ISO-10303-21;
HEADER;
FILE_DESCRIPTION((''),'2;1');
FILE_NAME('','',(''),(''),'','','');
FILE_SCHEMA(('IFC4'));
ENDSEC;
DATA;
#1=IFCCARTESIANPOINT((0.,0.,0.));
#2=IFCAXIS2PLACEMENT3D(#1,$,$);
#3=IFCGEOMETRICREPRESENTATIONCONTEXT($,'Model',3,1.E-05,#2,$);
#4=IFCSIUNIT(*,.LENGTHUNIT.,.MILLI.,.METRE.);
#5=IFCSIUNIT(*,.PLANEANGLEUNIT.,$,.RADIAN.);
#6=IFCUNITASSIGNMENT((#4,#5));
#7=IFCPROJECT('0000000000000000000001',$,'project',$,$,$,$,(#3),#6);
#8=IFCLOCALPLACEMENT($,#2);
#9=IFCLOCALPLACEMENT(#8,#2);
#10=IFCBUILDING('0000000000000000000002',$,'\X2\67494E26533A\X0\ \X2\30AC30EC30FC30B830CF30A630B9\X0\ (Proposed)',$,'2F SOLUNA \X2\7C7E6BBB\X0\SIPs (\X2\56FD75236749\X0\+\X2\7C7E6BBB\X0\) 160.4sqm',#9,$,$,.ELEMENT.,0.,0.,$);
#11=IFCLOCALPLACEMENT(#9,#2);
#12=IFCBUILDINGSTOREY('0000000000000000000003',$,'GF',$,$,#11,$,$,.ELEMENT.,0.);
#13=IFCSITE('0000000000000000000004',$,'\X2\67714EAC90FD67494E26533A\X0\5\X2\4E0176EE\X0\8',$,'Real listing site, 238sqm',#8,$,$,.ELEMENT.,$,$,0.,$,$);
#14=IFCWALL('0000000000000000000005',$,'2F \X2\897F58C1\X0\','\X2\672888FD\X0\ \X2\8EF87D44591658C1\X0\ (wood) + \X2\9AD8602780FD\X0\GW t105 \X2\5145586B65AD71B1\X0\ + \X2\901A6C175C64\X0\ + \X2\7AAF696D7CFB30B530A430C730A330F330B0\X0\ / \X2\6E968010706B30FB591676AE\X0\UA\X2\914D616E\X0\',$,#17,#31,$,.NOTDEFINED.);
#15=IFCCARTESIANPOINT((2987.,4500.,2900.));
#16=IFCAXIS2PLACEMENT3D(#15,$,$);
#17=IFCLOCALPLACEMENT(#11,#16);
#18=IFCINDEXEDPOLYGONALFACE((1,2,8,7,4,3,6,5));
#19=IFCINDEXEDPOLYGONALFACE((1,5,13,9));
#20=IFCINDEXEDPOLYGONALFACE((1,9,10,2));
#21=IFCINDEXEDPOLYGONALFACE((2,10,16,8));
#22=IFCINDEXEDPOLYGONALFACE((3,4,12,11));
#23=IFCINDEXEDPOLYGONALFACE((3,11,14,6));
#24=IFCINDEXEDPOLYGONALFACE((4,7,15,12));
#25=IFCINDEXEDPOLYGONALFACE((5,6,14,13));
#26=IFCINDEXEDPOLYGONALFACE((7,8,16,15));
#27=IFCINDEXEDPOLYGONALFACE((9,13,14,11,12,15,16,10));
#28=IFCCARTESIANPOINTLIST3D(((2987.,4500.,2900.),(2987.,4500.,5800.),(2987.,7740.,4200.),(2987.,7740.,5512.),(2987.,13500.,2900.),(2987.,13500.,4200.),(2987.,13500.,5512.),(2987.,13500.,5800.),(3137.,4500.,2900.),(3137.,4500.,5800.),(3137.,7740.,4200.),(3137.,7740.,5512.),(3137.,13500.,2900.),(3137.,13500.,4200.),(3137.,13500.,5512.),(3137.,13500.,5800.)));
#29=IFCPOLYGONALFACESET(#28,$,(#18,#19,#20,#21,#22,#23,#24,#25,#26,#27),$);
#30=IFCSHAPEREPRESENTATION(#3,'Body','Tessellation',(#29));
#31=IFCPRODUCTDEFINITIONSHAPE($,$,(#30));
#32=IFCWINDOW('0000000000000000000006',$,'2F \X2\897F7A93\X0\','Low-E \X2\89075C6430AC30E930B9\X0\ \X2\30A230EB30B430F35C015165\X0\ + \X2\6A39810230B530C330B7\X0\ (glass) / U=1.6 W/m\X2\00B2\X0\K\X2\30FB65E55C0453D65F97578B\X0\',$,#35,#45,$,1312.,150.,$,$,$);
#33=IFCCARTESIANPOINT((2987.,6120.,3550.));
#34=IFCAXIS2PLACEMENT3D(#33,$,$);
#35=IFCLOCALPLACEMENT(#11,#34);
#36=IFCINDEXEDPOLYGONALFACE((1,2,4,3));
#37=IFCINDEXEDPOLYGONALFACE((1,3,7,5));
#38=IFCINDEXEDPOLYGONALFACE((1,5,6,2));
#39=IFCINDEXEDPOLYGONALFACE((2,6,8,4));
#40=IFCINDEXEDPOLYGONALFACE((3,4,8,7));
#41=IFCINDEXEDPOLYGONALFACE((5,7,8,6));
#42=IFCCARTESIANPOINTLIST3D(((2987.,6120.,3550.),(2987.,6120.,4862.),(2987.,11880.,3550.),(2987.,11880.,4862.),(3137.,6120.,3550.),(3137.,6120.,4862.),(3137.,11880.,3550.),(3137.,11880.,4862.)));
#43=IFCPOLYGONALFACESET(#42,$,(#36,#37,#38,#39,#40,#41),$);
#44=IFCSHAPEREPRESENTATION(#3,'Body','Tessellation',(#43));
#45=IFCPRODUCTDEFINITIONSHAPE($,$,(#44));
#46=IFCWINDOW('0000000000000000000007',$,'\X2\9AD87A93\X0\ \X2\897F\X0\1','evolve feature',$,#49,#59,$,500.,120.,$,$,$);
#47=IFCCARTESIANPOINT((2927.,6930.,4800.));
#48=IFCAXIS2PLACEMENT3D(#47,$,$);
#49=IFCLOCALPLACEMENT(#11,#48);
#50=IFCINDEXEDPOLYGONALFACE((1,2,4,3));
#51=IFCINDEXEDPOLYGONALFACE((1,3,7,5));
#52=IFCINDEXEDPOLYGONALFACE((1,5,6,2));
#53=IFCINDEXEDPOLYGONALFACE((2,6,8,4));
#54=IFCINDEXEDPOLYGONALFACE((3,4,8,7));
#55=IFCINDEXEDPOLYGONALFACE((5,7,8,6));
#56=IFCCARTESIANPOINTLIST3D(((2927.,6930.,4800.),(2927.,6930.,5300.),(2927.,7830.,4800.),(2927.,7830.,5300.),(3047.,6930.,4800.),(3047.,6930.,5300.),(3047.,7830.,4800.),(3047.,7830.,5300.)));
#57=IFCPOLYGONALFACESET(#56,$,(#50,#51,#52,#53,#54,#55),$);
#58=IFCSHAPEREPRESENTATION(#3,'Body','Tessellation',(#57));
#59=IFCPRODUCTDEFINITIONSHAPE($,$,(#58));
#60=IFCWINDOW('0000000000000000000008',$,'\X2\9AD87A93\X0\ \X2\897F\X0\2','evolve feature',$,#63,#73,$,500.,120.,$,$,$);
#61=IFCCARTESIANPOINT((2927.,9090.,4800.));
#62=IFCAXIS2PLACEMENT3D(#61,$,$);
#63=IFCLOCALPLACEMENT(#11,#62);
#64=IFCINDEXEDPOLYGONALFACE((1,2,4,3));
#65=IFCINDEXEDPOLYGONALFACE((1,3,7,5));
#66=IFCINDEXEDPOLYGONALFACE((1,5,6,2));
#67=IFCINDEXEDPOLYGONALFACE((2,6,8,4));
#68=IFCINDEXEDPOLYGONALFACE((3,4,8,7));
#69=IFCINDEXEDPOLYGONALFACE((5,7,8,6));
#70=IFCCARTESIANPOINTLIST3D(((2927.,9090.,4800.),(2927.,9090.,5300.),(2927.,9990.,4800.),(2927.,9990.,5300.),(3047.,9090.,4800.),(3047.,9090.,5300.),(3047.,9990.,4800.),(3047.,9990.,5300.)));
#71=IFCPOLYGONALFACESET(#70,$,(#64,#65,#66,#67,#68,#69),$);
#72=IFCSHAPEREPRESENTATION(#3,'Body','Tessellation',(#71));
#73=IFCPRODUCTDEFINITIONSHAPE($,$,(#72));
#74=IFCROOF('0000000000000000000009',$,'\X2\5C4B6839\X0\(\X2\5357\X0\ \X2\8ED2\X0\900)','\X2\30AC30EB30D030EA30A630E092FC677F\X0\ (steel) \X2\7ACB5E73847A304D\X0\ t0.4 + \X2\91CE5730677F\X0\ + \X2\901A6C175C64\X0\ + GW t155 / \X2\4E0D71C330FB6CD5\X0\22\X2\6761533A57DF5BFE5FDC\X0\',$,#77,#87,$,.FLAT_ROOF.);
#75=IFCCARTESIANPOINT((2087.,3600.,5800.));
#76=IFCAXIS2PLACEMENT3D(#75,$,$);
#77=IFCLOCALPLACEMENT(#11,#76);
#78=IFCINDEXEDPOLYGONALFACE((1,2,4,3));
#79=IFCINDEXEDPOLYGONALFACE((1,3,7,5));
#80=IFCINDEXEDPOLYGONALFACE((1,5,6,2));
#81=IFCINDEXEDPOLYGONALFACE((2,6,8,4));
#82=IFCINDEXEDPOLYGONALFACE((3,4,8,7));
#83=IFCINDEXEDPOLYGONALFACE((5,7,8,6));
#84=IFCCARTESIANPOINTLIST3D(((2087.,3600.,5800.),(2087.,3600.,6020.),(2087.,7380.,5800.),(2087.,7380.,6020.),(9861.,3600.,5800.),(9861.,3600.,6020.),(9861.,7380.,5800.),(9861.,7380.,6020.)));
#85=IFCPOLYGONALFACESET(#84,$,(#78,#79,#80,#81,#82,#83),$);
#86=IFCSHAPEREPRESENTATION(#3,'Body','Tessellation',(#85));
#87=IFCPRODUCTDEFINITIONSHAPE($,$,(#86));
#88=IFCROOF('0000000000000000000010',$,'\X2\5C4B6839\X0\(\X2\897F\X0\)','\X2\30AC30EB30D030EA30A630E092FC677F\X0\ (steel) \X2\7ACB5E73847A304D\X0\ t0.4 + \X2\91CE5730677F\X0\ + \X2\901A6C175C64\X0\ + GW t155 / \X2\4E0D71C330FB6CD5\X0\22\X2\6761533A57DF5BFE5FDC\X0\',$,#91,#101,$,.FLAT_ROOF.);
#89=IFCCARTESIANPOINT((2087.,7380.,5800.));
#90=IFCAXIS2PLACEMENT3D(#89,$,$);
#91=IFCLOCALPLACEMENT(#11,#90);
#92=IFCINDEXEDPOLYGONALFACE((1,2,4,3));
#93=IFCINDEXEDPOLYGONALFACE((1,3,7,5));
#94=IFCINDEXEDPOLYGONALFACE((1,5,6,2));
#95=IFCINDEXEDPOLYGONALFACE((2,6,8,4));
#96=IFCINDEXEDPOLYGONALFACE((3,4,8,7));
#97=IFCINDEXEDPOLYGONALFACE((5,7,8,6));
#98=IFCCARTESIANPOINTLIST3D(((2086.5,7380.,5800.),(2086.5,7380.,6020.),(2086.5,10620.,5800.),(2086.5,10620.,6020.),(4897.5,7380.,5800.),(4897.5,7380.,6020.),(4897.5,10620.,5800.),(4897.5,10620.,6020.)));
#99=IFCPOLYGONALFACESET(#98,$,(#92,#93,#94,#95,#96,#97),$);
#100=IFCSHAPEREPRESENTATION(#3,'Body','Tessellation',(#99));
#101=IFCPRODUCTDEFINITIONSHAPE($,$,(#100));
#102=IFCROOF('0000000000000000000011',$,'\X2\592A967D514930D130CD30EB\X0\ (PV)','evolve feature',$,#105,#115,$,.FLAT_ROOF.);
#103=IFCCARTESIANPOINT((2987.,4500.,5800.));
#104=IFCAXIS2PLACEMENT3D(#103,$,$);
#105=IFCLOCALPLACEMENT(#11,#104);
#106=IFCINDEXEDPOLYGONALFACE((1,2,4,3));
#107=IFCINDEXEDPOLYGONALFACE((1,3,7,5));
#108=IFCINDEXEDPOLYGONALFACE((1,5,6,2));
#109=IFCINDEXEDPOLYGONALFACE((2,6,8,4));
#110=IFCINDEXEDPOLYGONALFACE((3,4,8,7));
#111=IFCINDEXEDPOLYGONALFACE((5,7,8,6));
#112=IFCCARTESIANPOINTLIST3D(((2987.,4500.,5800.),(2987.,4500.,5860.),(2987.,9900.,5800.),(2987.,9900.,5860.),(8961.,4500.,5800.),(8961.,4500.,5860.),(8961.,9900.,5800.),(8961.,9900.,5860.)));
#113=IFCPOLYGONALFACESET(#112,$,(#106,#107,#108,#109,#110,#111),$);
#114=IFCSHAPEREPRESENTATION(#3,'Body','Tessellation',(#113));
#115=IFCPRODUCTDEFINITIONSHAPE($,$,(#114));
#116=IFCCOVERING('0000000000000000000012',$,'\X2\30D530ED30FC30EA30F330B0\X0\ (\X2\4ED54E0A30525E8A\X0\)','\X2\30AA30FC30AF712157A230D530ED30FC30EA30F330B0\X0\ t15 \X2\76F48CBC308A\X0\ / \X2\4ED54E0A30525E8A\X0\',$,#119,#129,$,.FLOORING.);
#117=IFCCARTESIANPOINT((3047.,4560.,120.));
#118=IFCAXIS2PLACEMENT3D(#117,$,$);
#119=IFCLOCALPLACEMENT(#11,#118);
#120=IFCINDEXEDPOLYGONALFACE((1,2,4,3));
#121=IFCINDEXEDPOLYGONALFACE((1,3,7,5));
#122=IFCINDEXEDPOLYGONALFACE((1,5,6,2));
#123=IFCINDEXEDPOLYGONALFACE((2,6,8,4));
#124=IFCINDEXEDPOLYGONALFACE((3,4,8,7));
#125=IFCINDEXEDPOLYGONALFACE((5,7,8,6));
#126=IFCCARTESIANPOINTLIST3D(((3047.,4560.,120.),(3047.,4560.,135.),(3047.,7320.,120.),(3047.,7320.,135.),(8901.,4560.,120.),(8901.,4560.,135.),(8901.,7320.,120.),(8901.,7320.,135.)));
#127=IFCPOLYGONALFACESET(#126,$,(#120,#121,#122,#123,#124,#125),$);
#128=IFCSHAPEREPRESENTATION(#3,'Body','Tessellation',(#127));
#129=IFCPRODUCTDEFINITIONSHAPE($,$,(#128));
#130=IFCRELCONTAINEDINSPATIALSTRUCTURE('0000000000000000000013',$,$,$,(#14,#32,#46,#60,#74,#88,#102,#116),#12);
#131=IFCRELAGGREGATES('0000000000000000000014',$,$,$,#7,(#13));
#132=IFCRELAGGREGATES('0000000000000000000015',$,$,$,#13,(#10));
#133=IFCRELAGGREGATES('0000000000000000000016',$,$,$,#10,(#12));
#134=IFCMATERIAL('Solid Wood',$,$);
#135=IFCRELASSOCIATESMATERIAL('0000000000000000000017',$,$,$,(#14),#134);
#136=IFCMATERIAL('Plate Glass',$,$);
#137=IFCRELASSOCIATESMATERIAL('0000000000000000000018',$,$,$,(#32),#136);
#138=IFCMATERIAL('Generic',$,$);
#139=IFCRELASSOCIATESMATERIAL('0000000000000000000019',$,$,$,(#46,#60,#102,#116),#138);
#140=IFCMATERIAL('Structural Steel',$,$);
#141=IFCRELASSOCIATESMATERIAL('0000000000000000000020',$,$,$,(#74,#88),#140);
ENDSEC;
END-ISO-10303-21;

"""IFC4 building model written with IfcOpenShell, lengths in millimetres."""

from ifc_helpers import new_model, si_unit, frame, frame_2d, origin, place, context, project, spatial, rectangle, extrude, material, element, fill, save


model = new_model("IFC4")

# Units and contexts
model_context = context("Model", 3, precision=1e-05, world=origin())
ifc_project = project(units=[si_unit("LENGTHUNIT", "METRE", prefix="MILLI"), si_unit("PLANEANGLEUNIT", "RADIAN")], contexts=[model_context])

# Site, building, storey
site_placement = place(None, origin())
site = spatial("IfcSite", under=ifc_project, at=site_placement, Name="東京都杉並区5丁目8", ObjectType="Real listing site, 238sqm", CompositionType="ELEMENT", RefElevation=0.0)
building_placement = place(site_placement, origin())
building = spatial("IfcBuilding", under=site, at=building_placement, Name="杉並区 ガレージハウス (Proposed)", ObjectType="2F SOLUNA 籾殻SIPs (国産杉+籾殻) 160.4sqm", CompositionType="ELEMENT", ElevationOfRefHeight=0.0, ElevationOfTerrain=0.0)
storey_placement = place(building_placement, origin())
storey = spatial("IfcBuildingStorey", under=building, at=storey_placement, Name="GF", CompositionType="ELEMENT", Elevation=0.0)

# Shared definitions
ifc_material_1 = material(Name="Solid Wood")
ifc_material_2 = material(Name="Generic")

# Shared definitions
ifc_material_3 = material(Name="Plate Glass")

# Wall, openings, windows
wall_1_placement = place(storey_placement, frame((2987.0, 4500.0, 2900.0)))
wall_1 = element("IfcWall", 1, at=wall_1_placement, inside=storey, material=ifc_material_1, Name="2F 西壁", Description="木製 軸組外壁 (wood) + 高性能GW t105 充填断熱 + 通気層 + 窯業系サイディング / 準耐火・外皮UA配慮", PredefinedType="NOTDEFINED", context=model_context, shape_type="SweptSolid", body=[
    extrude(rectangle(XDim=150.0, YDim=9000.0, at=frame_2d((75.0, 4500.0))), frame((2987.0, 4500.0, 2900.0)), (0.0, 0.0, 1.0), 2900.0),
])
opening_1_placement = place(storey_placement, frame((2987.0, 6120.0, 3550.0)))
opening_1 = element("IfcOpeningElement", 2, at=opening_1_placement, cuts=wall_1, PredefinedType="NOTDEFINED", context=model_context, shape_type="SweptSolid", body=[
    extrude(rectangle(XDim=150.0, YDim=5760.0, at=frame_2d((75.0, 2880.0))), frame((2987.0, 6120.0, 3550.0)), (0.0, 0.0, 1.0), 1312.0),
])
opening_2_placement = place(storey_placement, frame((2927.0, 6930.0, 4800.0)))
opening_2 = element("IfcOpeningElement", 3, at=opening_2_placement, cuts=wall_1, PredefinedType="NOTDEFINED", context=model_context, shape_type="SweptSolid", body=[
    extrude(rectangle(XDim=120.0, YDim=900.0, at=frame_2d((60.0, 450.0))), frame((2927.0, 6930.0, 4800.0)), (0.0, 0.0, 1.0), 500.0),
])
opening_3_placement = place(storey_placement, frame((2927.0, 9090.0, 4800.0)))
opening_3 = element("IfcOpeningElement", 4, at=opening_3_placement, cuts=wall_1, PredefinedType="NOTDEFINED", context=model_context, shape_type="SweptSolid", body=[
    extrude(rectangle(XDim=120.0, YDim=900.0, at=frame_2d((60.0, 450.0))), frame((2927.0, 9090.0, 4800.0)), (0.0, 0.0, 1.0), 500.0),
])
window_1_placement = place(storey_placement, frame((2987.0, 6120.0, 3550.0)))
window_1 = element("IfcWindow", 5, at=window_1_placement, inside=storey, material=ifc_material_3, Name="2F 西窓", Description="Low-E 複層ガラス アルゴン封入 + 樹脂サッシ (glass) / U=1.6 W/m²K・日射取得型", OverallHeight=1312.0, OverallWidth=150.0, context=model_context, shape_type="SweptSolid", body=[
    extrude(rectangle(XDim=150.0, YDim=5760.0, at=frame_2d((75.0, 2880.0))), frame((2987.0, 6120.0, 3550.0)), (0.0, 0.0, 1.0), 1312.0),
])
fill(opening_1, window_1)
window_2_placement = place(storey_placement, frame((2927.0, 6930.0, 4800.0)))
window_2 = element("IfcWindow", 6, at=window_2_placement, inside=storey, material=ifc_material_2, Name="高窓 西1", Description="evolve feature", OverallHeight=500.0, OverallWidth=120.0, context=model_context, shape_type="SweptSolid", body=[
    extrude(rectangle(XDim=120.0, YDim=900.0, at=frame_2d((60.0, 450.0))), frame((2927.0, 6930.0, 4800.0)), (0.0, 0.0, 1.0), 500.0),
])
fill(opening_2, window_2)
window_3_placement = place(storey_placement, frame((2927.0, 9090.0, 4800.0)))
window_3 = element("IfcWindow", 7, at=window_3_placement, inside=storey, material=ifc_material_2, Name="高窓 西2", Description="evolve feature", OverallHeight=500.0, OverallWidth=120.0, context=model_context, shape_type="SweptSolid", body=[
    extrude(rectangle(XDim=120.0, YDim=900.0, at=frame_2d((60.0, 450.0))), frame((2927.0, 9090.0, 4800.0)), (0.0, 0.0, 1.0), 500.0),
])
fill(opening_3, window_3)

# Roofs
ifc_material_4 = material(Name="Structural Steel")
roof_1_placement = place(storey_placement, frame((2087.0, 3600.0, 5800.0)))
element("IfcRoof", 8, at=roof_1_placement, inside=storey, material=ifc_material_4, Name="屋根(南 軒900)", Description="ガルバリウム鋼板 (steel) 立平葺き t0.4 + 野地板 + 通気層 + GW t155 / 不燃・法22条区域対応", PredefinedType="FLAT_ROOF", context=model_context, shape_type="SweptSolid", body=[
    extrude(rectangle(XDim=7774.0, YDim=3780.0, at=frame_2d((3887.0, 1890.0))), frame((2087.0, 3600.0, 5800.0)), (0.0, 0.0, 1.0), 220.0),
])
roof_2_placement = place(storey_placement, frame((2087.0, 7380.0, 5800.0)))
element("IfcRoof", 9, at=roof_2_placement, inside=storey, material=ifc_material_4, Name="屋根(西)", Description="ガルバリウム鋼板 (steel) 立平葺き t0.4 + 野地板 + 通気層 + GW t155 / 不燃・法22条区域対応", PredefinedType="FLAT_ROOF", context=model_context, shape_type="SweptSolid", body=[
    extrude(rectangle(XDim=2811.0, YDim=3240.0, at=frame_2d((1405.0, 1620.0))), frame((2087.0, 7380.0, 5800.0)), (0.0, 0.0, 1.0), 220.0),
])
roof_3_placement = place(storey_placement, frame((2987.0, 4500.0, 5800.0)))
element("IfcRoof", 10, at=roof_3_placement, inside=storey, material=ifc_material_2, Name="太陽光パネル (PV)", Description="evolve feature", PredefinedType="FLAT_ROOF", context=model_context, shape_type="SweptSolid", body=[
    extrude(rectangle(XDim=5974.0, YDim=5400.0, at=frame_2d((2987.0, 2700.0))), frame((2987.0, 4500.0, 5800.0)), (0.0, 0.0, 1.0), 60.0),
])

# Covering
covering_placement = place(storey_placement, frame((3047.0, 4560.0, 120.0)))
element("IfcCovering", 11, at=covering_placement, inside=storey, material=ifc_material_2, Name="フローリング (仕上げ床)", Description="オーク無垢フローリング t15 直貼り / 仕上げ床", PredefinedType="FLOORING", context=model_context, shape_type="SweptSolid", body=[
    extrude(rectangle(XDim=5854.0, YDim=2760.0, at=frame_2d((2927.0, 1380.0))), frame((3047.0, 4560.0, 120.0)), (0.0, 0.0, 1.0), 15.0),
])

save(model, "model.ifc")
